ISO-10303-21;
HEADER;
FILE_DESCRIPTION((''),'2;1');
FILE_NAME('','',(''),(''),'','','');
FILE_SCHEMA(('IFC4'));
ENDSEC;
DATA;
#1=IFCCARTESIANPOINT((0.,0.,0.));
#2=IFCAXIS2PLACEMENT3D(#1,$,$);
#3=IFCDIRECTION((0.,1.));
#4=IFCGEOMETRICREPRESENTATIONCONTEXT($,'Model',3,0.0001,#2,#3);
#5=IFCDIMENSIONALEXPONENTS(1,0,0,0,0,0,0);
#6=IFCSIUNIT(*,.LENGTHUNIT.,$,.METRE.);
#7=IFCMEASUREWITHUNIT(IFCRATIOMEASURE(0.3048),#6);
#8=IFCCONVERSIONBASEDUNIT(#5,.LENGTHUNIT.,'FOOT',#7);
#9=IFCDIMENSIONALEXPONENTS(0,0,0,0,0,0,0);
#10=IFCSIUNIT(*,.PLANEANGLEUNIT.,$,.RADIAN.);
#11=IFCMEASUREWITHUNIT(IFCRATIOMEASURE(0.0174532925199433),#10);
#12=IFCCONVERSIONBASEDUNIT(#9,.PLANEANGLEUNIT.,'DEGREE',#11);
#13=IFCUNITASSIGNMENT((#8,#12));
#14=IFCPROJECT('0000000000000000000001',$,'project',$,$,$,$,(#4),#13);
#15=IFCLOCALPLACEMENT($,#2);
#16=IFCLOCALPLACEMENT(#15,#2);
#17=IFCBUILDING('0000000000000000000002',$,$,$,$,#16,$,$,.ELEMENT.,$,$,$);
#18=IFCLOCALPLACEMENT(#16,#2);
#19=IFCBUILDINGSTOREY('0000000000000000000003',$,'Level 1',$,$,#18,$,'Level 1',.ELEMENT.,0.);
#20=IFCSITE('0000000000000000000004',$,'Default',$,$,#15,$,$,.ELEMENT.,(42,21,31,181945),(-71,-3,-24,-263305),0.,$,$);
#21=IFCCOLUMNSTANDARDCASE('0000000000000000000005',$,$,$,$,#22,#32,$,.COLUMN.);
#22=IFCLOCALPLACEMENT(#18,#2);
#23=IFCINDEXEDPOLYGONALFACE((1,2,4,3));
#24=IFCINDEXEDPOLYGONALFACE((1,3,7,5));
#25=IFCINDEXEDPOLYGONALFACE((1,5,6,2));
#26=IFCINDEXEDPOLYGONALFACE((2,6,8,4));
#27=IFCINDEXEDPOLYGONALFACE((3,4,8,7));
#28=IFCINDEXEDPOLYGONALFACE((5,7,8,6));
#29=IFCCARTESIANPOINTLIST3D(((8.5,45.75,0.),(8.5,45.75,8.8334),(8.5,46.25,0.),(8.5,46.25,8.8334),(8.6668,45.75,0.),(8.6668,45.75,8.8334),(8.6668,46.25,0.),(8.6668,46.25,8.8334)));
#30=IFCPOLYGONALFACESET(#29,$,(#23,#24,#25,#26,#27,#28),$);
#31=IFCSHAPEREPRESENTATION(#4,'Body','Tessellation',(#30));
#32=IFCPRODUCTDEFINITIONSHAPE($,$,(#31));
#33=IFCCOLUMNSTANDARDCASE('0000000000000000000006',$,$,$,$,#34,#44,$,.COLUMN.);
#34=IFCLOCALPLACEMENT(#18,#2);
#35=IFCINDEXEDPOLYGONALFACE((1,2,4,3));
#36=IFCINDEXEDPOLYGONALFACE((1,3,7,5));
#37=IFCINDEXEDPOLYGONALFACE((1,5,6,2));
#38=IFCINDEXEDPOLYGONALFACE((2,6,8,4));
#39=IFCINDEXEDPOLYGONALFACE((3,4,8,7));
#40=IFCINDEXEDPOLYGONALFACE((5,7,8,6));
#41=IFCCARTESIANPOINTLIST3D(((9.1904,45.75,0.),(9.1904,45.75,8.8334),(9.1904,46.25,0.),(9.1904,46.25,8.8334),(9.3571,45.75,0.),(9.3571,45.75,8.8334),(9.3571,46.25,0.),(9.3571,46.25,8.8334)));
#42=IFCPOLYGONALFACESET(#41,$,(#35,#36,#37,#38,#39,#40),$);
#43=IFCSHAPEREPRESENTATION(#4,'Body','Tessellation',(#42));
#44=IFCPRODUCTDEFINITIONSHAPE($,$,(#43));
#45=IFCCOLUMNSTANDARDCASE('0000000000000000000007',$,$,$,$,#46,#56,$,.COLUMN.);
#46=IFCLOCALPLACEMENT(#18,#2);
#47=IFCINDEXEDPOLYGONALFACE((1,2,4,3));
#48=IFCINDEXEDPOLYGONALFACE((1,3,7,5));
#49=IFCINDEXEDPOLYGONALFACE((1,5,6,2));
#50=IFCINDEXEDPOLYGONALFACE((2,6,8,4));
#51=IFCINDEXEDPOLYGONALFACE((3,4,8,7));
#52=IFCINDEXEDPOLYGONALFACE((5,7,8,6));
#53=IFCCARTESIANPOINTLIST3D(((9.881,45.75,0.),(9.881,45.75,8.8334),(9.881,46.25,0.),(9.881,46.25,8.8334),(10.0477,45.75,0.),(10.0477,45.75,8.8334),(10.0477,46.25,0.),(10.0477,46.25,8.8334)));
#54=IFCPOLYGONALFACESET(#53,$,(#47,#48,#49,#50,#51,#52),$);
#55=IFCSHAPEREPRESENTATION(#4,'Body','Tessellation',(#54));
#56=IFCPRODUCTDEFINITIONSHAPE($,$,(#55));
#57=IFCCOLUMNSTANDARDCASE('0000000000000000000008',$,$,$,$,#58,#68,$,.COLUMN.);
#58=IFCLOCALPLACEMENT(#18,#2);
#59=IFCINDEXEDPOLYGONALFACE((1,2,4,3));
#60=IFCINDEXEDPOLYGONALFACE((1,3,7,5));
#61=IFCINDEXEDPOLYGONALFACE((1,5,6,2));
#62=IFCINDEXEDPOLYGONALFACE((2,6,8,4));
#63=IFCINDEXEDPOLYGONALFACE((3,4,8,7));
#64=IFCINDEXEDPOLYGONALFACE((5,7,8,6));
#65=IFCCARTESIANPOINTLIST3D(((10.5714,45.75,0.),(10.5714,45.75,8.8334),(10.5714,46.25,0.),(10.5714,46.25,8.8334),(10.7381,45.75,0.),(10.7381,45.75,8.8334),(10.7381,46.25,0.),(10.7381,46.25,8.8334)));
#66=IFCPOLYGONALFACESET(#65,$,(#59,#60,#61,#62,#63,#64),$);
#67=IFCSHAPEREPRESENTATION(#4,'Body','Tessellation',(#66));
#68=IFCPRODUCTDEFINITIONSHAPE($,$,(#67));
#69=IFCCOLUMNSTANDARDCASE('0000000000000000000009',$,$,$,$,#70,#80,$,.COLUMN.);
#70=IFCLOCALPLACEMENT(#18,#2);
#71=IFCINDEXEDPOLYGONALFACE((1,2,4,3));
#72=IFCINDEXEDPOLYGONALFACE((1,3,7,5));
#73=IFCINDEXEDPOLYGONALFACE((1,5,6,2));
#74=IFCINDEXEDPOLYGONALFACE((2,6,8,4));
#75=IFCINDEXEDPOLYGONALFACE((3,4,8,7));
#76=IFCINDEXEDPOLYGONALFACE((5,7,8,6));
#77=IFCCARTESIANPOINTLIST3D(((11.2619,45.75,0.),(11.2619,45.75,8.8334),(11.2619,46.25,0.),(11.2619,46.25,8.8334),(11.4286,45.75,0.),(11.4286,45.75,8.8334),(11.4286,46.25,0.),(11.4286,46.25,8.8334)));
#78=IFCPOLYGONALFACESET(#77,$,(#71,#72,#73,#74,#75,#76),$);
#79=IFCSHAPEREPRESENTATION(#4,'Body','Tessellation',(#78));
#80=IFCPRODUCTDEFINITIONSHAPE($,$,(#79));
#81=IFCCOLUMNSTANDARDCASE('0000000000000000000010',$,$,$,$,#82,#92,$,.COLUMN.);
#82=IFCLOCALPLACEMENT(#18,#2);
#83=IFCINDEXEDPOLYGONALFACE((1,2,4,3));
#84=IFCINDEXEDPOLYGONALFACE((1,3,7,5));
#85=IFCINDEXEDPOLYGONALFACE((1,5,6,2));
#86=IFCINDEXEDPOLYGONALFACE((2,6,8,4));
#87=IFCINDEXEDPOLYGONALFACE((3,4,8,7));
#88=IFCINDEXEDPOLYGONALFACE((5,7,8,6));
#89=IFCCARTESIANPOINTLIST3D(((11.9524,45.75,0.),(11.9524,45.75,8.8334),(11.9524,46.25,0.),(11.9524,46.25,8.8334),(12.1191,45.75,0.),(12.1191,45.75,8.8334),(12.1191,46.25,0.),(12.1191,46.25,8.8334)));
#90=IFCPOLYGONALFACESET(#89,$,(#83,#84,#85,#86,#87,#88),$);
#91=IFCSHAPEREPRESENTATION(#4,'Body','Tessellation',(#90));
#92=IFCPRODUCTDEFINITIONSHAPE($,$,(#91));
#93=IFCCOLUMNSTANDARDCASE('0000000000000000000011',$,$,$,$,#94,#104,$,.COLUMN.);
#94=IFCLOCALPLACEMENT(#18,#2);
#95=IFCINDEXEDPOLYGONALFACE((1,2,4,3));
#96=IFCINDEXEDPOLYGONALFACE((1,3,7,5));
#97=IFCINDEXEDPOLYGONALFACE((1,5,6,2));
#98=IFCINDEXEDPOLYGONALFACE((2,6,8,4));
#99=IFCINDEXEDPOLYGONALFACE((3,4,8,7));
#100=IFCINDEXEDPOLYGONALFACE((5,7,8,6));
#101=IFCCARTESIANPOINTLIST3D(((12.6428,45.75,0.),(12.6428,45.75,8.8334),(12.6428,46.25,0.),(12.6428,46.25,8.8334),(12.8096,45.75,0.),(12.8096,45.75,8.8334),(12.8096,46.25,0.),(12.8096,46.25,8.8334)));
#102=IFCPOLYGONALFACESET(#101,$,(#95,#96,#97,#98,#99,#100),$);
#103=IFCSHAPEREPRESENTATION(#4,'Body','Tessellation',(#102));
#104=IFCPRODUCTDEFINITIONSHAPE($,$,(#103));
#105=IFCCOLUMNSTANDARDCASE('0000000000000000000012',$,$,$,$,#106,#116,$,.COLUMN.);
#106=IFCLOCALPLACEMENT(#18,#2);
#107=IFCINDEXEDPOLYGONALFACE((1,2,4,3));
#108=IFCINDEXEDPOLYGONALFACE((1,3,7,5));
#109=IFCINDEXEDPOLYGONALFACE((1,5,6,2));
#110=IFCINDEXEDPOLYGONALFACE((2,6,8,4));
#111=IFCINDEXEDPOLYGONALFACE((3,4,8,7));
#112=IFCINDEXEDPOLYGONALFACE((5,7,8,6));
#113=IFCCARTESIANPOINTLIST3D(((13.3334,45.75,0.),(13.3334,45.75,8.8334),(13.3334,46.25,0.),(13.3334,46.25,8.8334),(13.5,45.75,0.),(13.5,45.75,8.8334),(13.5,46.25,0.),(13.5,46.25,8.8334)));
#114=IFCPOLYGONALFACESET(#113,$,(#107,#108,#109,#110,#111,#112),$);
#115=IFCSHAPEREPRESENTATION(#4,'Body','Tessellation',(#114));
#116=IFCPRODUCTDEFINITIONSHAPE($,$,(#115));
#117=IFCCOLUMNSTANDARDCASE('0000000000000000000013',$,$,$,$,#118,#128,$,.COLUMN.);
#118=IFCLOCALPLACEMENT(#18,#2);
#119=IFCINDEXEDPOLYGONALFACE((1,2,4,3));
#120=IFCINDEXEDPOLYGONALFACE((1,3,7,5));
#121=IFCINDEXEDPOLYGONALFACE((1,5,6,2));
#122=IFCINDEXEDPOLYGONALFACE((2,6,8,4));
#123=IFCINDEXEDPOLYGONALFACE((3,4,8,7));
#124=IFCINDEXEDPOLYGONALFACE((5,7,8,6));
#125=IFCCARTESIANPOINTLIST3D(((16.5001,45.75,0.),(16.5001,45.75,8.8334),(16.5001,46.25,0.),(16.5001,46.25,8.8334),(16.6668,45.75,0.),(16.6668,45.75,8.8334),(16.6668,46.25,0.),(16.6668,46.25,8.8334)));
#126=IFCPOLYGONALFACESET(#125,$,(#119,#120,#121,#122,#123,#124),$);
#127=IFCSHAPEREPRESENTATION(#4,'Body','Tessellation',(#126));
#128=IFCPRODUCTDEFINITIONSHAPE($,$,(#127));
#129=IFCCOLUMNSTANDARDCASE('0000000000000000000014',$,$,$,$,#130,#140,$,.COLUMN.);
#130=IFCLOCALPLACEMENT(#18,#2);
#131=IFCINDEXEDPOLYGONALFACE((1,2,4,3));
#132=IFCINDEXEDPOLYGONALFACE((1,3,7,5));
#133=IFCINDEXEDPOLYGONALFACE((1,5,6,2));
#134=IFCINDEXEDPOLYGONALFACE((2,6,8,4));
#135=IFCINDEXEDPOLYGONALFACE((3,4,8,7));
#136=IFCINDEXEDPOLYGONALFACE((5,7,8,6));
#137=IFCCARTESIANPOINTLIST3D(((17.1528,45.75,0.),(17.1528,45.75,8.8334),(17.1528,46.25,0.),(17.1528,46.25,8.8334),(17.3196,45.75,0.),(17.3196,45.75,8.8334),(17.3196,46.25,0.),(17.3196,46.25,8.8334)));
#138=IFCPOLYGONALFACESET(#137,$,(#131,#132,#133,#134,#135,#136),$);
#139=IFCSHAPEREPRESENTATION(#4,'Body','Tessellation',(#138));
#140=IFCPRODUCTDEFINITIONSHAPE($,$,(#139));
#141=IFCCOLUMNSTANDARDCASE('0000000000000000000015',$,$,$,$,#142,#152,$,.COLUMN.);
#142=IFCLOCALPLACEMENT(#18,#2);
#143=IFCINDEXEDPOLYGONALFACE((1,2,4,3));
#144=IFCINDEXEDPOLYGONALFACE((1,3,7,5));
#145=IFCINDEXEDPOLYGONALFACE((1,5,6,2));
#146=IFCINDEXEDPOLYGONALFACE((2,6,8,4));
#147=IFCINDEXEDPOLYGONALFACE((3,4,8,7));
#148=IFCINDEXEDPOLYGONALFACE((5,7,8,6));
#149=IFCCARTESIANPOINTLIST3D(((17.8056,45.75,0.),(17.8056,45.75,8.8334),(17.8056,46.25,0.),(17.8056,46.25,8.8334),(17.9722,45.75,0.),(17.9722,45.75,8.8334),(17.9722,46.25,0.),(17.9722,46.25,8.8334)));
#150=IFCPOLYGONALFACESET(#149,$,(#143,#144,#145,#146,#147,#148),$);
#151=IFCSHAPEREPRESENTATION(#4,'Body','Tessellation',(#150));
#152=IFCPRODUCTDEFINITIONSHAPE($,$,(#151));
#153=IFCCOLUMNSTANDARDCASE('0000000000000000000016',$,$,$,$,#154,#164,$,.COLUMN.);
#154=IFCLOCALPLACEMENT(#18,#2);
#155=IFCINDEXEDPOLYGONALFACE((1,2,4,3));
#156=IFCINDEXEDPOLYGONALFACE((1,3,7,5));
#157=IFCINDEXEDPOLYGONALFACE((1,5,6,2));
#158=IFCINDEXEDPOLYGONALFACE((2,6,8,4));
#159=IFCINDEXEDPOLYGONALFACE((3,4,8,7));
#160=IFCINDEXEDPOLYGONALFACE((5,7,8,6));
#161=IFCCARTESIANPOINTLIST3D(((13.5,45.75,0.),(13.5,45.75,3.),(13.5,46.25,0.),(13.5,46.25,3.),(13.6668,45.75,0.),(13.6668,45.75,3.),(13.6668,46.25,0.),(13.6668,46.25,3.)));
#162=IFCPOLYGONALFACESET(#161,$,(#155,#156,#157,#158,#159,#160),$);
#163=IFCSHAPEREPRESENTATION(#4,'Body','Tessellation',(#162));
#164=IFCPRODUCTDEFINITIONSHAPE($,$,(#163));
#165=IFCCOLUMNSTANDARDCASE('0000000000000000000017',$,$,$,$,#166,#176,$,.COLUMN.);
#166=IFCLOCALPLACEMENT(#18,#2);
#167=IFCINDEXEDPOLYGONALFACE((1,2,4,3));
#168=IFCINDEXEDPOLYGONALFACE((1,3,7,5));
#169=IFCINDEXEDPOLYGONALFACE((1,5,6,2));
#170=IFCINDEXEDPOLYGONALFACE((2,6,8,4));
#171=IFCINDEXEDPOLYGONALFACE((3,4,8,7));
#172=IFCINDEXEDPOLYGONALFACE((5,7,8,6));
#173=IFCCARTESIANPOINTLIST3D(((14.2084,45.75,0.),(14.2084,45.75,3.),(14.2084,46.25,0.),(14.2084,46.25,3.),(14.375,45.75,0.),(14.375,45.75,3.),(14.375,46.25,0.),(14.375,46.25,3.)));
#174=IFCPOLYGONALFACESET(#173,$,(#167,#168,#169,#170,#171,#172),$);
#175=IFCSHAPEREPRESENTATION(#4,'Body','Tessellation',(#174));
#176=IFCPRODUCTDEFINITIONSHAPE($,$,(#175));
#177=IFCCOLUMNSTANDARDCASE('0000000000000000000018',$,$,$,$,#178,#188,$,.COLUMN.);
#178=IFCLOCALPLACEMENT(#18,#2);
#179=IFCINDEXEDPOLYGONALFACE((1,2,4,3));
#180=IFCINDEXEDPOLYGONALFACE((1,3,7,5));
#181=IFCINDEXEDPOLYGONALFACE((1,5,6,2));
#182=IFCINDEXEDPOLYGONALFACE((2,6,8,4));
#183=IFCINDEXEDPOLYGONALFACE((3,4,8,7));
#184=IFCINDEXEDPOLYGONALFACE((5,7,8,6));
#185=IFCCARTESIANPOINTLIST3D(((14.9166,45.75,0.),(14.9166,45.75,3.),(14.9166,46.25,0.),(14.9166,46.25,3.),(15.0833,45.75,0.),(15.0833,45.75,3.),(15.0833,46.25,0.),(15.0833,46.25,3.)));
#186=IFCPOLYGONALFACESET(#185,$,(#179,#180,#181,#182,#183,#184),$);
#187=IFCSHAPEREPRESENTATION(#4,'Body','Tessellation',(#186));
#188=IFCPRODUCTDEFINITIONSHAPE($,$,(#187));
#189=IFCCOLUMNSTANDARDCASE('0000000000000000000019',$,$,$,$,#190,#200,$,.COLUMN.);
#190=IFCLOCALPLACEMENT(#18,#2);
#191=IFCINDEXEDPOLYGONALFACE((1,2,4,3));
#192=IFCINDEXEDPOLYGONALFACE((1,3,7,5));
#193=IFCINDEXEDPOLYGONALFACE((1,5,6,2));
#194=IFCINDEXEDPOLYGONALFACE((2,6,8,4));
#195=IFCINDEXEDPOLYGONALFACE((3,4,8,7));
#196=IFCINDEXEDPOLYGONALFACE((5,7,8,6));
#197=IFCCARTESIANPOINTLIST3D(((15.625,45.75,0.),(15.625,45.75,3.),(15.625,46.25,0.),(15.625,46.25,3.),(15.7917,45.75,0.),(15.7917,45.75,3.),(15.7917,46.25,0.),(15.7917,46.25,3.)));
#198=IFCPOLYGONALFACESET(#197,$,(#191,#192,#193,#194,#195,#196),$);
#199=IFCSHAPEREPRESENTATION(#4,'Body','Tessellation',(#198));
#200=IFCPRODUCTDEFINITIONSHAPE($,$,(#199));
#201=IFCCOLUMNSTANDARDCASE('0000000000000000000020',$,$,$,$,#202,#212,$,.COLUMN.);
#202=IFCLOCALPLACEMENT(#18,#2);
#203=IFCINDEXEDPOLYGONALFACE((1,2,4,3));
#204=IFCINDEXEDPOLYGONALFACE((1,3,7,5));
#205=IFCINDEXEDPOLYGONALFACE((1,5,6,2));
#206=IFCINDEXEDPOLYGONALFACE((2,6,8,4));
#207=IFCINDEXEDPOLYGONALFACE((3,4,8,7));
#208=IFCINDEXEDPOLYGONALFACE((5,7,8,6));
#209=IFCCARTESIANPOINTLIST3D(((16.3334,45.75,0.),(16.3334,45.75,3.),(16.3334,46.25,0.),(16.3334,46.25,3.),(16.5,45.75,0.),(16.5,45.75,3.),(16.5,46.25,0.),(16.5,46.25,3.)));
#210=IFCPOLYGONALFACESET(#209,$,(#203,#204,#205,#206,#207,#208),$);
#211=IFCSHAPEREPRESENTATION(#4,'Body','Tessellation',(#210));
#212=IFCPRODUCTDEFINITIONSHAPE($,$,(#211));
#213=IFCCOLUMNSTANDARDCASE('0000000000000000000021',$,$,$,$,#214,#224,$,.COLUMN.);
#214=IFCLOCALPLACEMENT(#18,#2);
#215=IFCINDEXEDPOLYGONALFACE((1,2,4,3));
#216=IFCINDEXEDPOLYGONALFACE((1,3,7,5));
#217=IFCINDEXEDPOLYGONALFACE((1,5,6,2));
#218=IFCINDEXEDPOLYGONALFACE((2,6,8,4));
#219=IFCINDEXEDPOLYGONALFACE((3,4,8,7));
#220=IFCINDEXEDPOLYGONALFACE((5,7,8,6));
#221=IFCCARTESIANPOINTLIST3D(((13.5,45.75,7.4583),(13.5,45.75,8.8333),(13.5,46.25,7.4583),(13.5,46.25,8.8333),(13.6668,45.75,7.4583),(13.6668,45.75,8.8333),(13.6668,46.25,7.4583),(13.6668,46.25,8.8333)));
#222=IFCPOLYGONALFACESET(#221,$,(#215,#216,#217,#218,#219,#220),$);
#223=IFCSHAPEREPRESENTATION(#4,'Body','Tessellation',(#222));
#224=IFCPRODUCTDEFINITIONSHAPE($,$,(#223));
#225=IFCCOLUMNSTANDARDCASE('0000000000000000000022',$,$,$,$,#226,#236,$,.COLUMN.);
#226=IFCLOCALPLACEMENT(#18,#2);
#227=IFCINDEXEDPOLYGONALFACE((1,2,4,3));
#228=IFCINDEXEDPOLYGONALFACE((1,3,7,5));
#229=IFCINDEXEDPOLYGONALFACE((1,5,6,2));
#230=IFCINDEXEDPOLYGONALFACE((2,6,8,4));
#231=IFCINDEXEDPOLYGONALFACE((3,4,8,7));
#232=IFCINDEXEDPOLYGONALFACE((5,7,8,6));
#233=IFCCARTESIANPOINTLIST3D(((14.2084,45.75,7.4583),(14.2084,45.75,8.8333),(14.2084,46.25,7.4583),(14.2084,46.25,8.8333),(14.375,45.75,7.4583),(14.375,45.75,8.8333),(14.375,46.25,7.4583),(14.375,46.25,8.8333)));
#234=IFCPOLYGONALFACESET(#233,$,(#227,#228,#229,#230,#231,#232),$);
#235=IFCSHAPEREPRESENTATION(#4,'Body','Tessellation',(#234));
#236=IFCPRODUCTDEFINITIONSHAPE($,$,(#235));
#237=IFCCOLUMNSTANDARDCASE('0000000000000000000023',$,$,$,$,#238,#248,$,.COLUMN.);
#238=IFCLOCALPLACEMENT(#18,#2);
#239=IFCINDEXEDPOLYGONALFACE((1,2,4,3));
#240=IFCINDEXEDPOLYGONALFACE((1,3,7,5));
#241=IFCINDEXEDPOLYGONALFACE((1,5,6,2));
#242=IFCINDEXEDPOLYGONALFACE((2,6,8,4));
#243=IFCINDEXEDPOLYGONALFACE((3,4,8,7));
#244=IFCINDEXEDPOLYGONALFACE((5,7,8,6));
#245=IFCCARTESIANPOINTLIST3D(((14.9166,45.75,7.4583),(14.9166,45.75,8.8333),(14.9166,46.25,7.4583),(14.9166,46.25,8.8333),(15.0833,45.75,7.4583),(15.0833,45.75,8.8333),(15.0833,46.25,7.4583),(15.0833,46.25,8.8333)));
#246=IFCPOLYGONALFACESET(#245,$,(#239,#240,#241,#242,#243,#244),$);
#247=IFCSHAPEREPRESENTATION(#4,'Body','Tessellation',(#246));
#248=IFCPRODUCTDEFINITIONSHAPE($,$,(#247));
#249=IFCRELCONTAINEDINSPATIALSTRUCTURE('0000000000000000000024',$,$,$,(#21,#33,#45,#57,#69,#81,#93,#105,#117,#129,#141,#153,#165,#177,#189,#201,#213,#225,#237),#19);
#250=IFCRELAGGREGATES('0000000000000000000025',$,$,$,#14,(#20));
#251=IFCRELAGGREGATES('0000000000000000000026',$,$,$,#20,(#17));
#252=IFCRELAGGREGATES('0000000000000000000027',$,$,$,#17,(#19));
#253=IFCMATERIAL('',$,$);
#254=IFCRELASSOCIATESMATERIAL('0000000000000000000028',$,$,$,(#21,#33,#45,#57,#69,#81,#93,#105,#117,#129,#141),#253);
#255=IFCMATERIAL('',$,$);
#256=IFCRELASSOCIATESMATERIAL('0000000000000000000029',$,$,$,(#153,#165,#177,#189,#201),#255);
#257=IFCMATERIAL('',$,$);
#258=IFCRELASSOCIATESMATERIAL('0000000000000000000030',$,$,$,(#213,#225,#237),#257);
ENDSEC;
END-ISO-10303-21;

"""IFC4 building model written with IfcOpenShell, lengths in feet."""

from ifc_helpers import new_model, entity, si_unit, converted_unit, direction, frame, origin, place, context, project, spatial, rectangle, extrude, material, element, save


model = new_model("IFC4")

# Units and contexts
model_context = context("Model", 3, precision=0.0001, world=origin(), true_north=direction((0.0, 1.0)))
ifc_project = project(units=[converted_unit("LENGTHUNIT", "FOOT", entity("IfcRatioMeasure", 0.3048), si_unit("LENGTHUNIT", "METRE"), dimensions=[1, 0, 0, 0, 0, 0, 0]), converted_unit("PLANEANGLEUNIT", "DEGREE", entity("IfcRatioMeasure", 0.0174532925199433), si_unit("PLANEANGLEUNIT", "RADIAN"), dimensions=[0, 0, 0, 0, 0, 0, 0])], contexts=[model_context])

# Site, building, storey
site_placement = place(None, origin())
site = spatial("IfcSite", under=ifc_project, at=site_placement, Name="Default", CompositionType="ELEMENT", RefLatitude=(42, 21, 31, 181945), RefLongitude=(-71, -3, -24, -263305), RefElevation=0.0)
building_placement = place(site_placement, origin())
building = spatial("IfcBuilding", under=site, at=building_placement, CompositionType="ELEMENT")
storey_placement = place(building_placement, origin())
storey = spatial("IfcBuildingStorey", under=building, at=storey_placement, Name="Level 1", LongName="Level 1", CompositionType="ELEMENT", Elevation=0.0)

# Columns
ifc_material_1 = material(Name="")
placement_1 = place(storey_placement, frame((-0.25, 46.0, 0.0)))
for number, where, z_axis, x_axis in (
    (1, (8.8334, 0.0, 0.0), (0.0, 0.0, 1.0), (1.0, 0.0, 0.0)),
    (2, (9.5238, 0.0, 0.0), (0.0, 0.0, 1.0), (1.0, 0.0, 0.0)),
    (3, (10.2143, 0.0, 0.0), (0.0, 0.0, 1.0), (1.0, 0.0, 0.0)),
    (4, (10.9048, 0.0, 0.0), (0.0, 0.0, 1.0), (1.0, 0.0, 0.0)),
    (5, (11.5953, 0.0, 0.0), (0.0, 0.0, 1.0), (1.0, 0.0, 0.0)),
    (6, (12.2857, 0.0, 0.0), (0.0, 0.0, 1.0), (1.0, 0.0, 0.0)),
    (7, (12.9762, 0.0, 0.0), (0.0, 0.0, 1.0), (1.0, 0.0, 0.0)),
    (8, (13.6667, 0.0, 0.0), (0.0, 0.0, 1.0), (1.0, 0.0, 0.0)),
    (9, (16.8334, 0.0, 0.0), (0.0, 0.0, 1.0), (1.0, 0.0, 0.0)),
    (10, (17.4862, 0.0, 0.0), (0.0, 0.0, 1.0), (1.0, 0.0, 0.0)),
    (11, (18.1389, 0.0, 0.0), (0.0, 0.0, 1.0), (1.0, 0.0, 0.0)),
):
    element("IfcColumnStandardCase", number, at=place(placement_1, frame(where, z_axis=z_axis, x_axis=x_axis)), inside=storey, material=ifc_material_1, PredefinedType="COLUMN", context=model_context, shape_type="SweptSolid", body=[
        extrude(rectangle(XDim=0.1667, YDim=0.5), origin(), (0.0, 0.0, 1.0), 8.8334),
    ])
ifc_material_2 = material(Name="")
for number, where, z_axis, x_axis in (
    (12, (13.8334, 0.0, 0.0), (0.0, 0.0, 1.0), (1.0, 0.0, 0.0)),
    (13, (14.5417, 0.0, 0.0), (0.0, 0.0, 1.0), (1.0, 0.0, 0.0)),
    (14, (15.25, 0.0, 0.0), (0.0, 0.0, 1.0), (1.0, 0.0, 0.0)),
    (15, (15.9584, 0.0, 0.0), (0.0, 0.0, 1.0), (1.0, 0.0, 0.0)),
    (16, (16.6667, 0.0, 0.0), (0.0, 0.0, 1.0), (1.0, 0.0, 0.0)),
):
    element("IfcColumnStandardCase", number, at=place(placement_1, frame(where, z_axis=z_axis, x_axis=x_axis)), inside=storey, material=ifc_material_2, PredefinedType="COLUMN", context=model_context, shape_type="SweptSolid", body=[
        extrude(rectangle(XDim=0.1667, YDim=0.5), origin(), (0.0, 0.0, 1.0), 3.0),
    ])
ifc_material_3 = material(Name="")
for number, where, z_axis, x_axis in (
    (17, (13.8334, 0.0, 7.4583), (0.0, 0.0, 1.0), (1.0, 0.0, 0.0)),
    (18, (14.5417, 0.0, 7.4583), (0.0, 0.0, 1.0), (1.0, 0.0, 0.0)),
    (19, (15.25, 0.0, 7.4583), (0.0, 0.0, 1.0), (1.0, 0.0, 0.0)),
):
    element("IfcColumnStandardCase", number, at=place(placement_1, frame(where, z_axis=z_axis, x_axis=x_axis)), inside=storey, material=ifc_material_3, PredefinedType="COLUMN", context=model_context, shape_type="SweptSolid", body=[
        extrude(rectangle(XDim=0.1667, YDim=0.5), origin(), (0.0, 0.0, 1.0), 1.375),
    ])

save(model, "model.ifc")
